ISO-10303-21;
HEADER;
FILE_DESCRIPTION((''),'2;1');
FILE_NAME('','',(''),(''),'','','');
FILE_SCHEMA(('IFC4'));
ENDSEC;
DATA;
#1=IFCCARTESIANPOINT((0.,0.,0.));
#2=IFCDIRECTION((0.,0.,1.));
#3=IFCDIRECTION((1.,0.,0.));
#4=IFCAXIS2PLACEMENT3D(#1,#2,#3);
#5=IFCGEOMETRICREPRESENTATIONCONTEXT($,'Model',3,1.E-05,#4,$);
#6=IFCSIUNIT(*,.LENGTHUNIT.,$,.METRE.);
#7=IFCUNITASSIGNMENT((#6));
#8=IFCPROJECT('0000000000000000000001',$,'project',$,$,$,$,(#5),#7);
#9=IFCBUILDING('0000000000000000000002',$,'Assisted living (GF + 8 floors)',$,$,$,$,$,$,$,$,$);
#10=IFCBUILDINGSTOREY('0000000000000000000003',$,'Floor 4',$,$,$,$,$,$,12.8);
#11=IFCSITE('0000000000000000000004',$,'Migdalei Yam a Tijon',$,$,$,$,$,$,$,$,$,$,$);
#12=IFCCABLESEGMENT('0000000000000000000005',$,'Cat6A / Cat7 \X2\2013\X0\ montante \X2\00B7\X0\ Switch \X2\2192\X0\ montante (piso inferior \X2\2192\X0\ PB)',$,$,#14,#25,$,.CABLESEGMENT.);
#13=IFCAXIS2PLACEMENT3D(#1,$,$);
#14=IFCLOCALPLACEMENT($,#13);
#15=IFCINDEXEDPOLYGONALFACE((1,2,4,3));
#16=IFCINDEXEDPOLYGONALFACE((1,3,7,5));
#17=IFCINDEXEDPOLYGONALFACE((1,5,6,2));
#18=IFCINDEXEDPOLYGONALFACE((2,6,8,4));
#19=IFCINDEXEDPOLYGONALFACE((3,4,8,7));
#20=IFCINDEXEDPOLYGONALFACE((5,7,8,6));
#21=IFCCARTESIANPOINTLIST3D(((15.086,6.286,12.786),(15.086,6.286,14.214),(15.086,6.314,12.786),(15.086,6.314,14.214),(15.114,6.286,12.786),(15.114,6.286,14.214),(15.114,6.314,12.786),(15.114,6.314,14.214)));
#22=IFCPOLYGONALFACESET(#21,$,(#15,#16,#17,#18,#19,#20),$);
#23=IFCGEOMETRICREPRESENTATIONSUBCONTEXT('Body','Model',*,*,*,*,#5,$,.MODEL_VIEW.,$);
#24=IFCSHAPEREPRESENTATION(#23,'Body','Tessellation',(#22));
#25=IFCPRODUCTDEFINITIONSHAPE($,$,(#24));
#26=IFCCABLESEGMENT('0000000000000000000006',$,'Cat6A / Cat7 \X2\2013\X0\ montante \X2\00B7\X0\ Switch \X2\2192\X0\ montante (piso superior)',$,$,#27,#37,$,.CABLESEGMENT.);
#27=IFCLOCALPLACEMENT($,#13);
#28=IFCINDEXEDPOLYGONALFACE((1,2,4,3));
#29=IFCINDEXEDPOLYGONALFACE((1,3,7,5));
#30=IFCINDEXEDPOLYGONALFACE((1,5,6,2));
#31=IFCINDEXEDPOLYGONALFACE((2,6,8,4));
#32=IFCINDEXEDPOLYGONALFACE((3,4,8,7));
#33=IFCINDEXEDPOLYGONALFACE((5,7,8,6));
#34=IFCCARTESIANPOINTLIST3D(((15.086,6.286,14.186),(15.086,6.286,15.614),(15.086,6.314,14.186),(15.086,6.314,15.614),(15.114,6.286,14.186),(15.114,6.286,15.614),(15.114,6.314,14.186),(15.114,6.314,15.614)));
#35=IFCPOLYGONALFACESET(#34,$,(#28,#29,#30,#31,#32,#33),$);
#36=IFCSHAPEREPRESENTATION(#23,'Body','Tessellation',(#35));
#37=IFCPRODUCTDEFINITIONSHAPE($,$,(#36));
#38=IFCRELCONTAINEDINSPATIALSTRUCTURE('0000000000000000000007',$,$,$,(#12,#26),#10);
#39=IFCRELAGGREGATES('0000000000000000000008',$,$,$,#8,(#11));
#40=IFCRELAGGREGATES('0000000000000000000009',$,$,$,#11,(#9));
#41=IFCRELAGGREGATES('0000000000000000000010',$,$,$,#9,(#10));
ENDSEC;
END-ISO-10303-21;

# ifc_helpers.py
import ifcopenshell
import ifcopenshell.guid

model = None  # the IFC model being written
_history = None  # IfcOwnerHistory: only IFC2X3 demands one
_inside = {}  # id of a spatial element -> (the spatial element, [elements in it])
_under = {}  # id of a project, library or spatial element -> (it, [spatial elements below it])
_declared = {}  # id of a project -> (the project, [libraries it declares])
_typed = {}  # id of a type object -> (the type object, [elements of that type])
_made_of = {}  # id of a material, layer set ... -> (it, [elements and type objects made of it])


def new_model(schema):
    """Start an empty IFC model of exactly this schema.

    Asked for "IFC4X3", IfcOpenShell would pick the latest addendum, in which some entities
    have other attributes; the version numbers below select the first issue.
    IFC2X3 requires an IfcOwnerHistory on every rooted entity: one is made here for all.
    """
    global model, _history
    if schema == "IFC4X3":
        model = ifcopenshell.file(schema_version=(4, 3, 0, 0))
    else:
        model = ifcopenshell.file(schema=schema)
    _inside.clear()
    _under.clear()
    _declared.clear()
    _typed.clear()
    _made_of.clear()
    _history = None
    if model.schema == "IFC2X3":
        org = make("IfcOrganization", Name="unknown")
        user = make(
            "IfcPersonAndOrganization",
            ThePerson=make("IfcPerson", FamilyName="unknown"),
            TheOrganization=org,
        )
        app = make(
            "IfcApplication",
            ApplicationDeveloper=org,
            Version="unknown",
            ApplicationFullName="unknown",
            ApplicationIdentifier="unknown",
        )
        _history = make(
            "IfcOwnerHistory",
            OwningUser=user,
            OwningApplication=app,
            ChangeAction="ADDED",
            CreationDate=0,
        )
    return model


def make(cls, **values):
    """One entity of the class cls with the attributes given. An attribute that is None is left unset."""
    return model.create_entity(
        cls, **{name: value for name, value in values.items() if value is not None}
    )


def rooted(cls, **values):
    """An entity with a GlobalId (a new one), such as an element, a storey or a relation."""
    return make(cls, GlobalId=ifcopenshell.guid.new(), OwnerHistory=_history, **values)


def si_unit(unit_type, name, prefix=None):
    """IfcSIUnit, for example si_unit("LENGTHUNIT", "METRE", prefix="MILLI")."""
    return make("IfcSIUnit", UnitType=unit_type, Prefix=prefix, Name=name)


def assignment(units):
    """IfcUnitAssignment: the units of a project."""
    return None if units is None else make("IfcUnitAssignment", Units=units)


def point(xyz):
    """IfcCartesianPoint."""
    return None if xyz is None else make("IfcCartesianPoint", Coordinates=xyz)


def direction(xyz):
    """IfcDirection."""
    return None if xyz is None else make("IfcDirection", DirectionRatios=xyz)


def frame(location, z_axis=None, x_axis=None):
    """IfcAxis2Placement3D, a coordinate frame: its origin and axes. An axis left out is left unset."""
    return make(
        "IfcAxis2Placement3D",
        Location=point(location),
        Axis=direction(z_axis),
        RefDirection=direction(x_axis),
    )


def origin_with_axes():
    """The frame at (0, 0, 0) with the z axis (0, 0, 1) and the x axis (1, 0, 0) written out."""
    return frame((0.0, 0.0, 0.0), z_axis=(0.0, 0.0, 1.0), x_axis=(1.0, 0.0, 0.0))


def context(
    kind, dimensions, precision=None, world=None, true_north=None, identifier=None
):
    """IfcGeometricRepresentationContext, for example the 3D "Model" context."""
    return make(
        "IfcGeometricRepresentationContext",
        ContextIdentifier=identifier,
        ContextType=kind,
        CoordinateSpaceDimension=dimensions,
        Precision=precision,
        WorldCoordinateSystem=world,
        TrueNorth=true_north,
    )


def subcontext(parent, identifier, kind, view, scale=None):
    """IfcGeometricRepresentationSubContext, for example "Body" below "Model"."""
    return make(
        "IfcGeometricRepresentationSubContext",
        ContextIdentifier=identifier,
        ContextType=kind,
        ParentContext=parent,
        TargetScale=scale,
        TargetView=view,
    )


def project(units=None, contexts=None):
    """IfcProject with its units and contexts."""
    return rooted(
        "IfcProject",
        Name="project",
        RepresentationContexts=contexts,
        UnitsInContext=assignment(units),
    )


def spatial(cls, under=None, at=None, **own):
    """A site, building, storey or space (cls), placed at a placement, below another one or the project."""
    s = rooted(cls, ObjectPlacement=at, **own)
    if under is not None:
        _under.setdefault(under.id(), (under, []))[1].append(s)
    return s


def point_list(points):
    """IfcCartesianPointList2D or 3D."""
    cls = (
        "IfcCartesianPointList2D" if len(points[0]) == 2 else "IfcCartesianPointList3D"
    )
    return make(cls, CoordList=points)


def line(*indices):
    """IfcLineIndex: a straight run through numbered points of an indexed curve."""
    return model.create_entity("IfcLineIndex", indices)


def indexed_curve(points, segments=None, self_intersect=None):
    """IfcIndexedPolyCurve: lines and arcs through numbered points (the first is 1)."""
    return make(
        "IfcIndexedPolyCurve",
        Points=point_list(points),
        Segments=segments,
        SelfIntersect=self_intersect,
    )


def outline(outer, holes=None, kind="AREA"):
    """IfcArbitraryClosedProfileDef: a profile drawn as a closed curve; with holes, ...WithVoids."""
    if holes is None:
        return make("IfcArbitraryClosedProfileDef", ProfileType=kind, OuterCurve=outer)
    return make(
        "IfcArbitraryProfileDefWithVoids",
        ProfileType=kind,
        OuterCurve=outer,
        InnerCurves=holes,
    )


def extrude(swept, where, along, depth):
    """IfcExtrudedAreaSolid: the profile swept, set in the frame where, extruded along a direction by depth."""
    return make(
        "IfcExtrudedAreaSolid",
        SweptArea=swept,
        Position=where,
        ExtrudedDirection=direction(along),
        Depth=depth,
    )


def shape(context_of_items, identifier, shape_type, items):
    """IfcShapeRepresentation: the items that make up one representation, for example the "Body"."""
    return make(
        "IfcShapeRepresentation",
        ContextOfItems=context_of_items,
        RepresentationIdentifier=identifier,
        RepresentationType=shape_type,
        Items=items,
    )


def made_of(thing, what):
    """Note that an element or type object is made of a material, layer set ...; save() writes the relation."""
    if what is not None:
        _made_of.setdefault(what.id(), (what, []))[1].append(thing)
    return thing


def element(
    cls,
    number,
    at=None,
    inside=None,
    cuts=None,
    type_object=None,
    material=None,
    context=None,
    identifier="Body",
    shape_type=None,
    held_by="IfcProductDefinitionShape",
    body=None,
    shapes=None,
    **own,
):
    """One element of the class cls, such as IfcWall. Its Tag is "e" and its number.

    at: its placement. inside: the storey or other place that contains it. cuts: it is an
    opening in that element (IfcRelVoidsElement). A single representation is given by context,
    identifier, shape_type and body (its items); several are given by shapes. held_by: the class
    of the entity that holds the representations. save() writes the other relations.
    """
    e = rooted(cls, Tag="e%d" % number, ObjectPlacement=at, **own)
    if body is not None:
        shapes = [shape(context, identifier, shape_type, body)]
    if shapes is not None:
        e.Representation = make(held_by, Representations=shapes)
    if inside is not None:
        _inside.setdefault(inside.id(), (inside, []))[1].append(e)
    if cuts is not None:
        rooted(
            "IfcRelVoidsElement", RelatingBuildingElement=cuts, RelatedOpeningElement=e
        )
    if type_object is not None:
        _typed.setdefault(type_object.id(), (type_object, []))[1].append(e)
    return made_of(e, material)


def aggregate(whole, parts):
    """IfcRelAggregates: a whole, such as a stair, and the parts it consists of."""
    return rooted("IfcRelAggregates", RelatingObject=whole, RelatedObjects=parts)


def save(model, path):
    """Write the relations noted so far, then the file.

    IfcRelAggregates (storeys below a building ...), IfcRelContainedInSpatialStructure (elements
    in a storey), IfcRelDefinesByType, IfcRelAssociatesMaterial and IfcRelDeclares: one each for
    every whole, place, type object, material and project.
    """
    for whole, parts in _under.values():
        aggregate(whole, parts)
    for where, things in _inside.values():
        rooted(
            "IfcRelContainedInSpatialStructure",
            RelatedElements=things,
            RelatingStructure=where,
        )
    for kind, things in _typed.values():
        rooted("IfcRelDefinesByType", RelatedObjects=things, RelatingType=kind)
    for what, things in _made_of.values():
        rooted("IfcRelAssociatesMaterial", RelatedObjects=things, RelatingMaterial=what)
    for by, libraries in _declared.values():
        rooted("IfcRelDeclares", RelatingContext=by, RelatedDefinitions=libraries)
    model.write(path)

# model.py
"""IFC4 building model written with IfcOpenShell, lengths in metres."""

from ifc_helpers import new_model, si_unit, frame, origin_with_axes, context, subcontext, project, spatial, line, indexed_curve, outline, extrude, element, save


model = new_model("IFC4")

# Units and contexts
model_context = context("Model", 3, precision=1e-05, world=origin_with_axes())
body_context = subcontext(model_context, "Body", "Model", "MODEL_VIEW")
ifc_project = project(units=[si_unit("LENGTHUNIT", "METRE")], contexts=[model_context])

# Site, building, storey
site = spatial("IfcSite", under=ifc_project, Name="Migdalei Yam a Tijon")
building = spatial("IfcBuilding", under=site, Name="Assisted living (GF + 8 floors)")
storey = spatial("IfcBuildingStorey", under=building, Name="Floor 4", Elevation=12.8)

# Cable segments
element("IfcCableSegment", 1, inside=storey, Name="Cat6A / Cat7 – montante · Switch → montante (piso inferior → PB)", PredefinedType="CABLESEGMENT", context=body_context, shape_type="SweptSolid", body=[
    extrude(outline(indexed_curve([(0.0, 0.0), (0.028, 0.0), (0.028, 0.028), (0.0, 0.028)], segments=[line(1, 2, 3, 4, 1)])), frame((15.086, 6.286, 12.786), z_axis=(0.0, 0.0, 1.0), x_axis=(1.0, 0.0, 0.0)), (0.0, 0.0, 1.0), 1.428),
])
element("IfcCableSegment", 2, inside=storey, Name="Cat6A / Cat7 – montante · Switch → montante (piso superior)", PredefinedType="CABLESEGMENT", context=body_context, shape_type="SweptSolid", body=[
    extrude(outline(indexed_curve([(0.0, 0.0), (0.028, 0.0), (0.028, 0.028), (0.0, 0.028)], segments=[line(1, 2, 3, 4, 1)])), frame((15.086, 6.286, 14.186), z_axis=(0.0, 0.0, 1.0), x_axis=(1.0, 0.0, 0.0)), (0.0, 0.0, 1.0), 1.428),
])

save(model, "model.ifc")
